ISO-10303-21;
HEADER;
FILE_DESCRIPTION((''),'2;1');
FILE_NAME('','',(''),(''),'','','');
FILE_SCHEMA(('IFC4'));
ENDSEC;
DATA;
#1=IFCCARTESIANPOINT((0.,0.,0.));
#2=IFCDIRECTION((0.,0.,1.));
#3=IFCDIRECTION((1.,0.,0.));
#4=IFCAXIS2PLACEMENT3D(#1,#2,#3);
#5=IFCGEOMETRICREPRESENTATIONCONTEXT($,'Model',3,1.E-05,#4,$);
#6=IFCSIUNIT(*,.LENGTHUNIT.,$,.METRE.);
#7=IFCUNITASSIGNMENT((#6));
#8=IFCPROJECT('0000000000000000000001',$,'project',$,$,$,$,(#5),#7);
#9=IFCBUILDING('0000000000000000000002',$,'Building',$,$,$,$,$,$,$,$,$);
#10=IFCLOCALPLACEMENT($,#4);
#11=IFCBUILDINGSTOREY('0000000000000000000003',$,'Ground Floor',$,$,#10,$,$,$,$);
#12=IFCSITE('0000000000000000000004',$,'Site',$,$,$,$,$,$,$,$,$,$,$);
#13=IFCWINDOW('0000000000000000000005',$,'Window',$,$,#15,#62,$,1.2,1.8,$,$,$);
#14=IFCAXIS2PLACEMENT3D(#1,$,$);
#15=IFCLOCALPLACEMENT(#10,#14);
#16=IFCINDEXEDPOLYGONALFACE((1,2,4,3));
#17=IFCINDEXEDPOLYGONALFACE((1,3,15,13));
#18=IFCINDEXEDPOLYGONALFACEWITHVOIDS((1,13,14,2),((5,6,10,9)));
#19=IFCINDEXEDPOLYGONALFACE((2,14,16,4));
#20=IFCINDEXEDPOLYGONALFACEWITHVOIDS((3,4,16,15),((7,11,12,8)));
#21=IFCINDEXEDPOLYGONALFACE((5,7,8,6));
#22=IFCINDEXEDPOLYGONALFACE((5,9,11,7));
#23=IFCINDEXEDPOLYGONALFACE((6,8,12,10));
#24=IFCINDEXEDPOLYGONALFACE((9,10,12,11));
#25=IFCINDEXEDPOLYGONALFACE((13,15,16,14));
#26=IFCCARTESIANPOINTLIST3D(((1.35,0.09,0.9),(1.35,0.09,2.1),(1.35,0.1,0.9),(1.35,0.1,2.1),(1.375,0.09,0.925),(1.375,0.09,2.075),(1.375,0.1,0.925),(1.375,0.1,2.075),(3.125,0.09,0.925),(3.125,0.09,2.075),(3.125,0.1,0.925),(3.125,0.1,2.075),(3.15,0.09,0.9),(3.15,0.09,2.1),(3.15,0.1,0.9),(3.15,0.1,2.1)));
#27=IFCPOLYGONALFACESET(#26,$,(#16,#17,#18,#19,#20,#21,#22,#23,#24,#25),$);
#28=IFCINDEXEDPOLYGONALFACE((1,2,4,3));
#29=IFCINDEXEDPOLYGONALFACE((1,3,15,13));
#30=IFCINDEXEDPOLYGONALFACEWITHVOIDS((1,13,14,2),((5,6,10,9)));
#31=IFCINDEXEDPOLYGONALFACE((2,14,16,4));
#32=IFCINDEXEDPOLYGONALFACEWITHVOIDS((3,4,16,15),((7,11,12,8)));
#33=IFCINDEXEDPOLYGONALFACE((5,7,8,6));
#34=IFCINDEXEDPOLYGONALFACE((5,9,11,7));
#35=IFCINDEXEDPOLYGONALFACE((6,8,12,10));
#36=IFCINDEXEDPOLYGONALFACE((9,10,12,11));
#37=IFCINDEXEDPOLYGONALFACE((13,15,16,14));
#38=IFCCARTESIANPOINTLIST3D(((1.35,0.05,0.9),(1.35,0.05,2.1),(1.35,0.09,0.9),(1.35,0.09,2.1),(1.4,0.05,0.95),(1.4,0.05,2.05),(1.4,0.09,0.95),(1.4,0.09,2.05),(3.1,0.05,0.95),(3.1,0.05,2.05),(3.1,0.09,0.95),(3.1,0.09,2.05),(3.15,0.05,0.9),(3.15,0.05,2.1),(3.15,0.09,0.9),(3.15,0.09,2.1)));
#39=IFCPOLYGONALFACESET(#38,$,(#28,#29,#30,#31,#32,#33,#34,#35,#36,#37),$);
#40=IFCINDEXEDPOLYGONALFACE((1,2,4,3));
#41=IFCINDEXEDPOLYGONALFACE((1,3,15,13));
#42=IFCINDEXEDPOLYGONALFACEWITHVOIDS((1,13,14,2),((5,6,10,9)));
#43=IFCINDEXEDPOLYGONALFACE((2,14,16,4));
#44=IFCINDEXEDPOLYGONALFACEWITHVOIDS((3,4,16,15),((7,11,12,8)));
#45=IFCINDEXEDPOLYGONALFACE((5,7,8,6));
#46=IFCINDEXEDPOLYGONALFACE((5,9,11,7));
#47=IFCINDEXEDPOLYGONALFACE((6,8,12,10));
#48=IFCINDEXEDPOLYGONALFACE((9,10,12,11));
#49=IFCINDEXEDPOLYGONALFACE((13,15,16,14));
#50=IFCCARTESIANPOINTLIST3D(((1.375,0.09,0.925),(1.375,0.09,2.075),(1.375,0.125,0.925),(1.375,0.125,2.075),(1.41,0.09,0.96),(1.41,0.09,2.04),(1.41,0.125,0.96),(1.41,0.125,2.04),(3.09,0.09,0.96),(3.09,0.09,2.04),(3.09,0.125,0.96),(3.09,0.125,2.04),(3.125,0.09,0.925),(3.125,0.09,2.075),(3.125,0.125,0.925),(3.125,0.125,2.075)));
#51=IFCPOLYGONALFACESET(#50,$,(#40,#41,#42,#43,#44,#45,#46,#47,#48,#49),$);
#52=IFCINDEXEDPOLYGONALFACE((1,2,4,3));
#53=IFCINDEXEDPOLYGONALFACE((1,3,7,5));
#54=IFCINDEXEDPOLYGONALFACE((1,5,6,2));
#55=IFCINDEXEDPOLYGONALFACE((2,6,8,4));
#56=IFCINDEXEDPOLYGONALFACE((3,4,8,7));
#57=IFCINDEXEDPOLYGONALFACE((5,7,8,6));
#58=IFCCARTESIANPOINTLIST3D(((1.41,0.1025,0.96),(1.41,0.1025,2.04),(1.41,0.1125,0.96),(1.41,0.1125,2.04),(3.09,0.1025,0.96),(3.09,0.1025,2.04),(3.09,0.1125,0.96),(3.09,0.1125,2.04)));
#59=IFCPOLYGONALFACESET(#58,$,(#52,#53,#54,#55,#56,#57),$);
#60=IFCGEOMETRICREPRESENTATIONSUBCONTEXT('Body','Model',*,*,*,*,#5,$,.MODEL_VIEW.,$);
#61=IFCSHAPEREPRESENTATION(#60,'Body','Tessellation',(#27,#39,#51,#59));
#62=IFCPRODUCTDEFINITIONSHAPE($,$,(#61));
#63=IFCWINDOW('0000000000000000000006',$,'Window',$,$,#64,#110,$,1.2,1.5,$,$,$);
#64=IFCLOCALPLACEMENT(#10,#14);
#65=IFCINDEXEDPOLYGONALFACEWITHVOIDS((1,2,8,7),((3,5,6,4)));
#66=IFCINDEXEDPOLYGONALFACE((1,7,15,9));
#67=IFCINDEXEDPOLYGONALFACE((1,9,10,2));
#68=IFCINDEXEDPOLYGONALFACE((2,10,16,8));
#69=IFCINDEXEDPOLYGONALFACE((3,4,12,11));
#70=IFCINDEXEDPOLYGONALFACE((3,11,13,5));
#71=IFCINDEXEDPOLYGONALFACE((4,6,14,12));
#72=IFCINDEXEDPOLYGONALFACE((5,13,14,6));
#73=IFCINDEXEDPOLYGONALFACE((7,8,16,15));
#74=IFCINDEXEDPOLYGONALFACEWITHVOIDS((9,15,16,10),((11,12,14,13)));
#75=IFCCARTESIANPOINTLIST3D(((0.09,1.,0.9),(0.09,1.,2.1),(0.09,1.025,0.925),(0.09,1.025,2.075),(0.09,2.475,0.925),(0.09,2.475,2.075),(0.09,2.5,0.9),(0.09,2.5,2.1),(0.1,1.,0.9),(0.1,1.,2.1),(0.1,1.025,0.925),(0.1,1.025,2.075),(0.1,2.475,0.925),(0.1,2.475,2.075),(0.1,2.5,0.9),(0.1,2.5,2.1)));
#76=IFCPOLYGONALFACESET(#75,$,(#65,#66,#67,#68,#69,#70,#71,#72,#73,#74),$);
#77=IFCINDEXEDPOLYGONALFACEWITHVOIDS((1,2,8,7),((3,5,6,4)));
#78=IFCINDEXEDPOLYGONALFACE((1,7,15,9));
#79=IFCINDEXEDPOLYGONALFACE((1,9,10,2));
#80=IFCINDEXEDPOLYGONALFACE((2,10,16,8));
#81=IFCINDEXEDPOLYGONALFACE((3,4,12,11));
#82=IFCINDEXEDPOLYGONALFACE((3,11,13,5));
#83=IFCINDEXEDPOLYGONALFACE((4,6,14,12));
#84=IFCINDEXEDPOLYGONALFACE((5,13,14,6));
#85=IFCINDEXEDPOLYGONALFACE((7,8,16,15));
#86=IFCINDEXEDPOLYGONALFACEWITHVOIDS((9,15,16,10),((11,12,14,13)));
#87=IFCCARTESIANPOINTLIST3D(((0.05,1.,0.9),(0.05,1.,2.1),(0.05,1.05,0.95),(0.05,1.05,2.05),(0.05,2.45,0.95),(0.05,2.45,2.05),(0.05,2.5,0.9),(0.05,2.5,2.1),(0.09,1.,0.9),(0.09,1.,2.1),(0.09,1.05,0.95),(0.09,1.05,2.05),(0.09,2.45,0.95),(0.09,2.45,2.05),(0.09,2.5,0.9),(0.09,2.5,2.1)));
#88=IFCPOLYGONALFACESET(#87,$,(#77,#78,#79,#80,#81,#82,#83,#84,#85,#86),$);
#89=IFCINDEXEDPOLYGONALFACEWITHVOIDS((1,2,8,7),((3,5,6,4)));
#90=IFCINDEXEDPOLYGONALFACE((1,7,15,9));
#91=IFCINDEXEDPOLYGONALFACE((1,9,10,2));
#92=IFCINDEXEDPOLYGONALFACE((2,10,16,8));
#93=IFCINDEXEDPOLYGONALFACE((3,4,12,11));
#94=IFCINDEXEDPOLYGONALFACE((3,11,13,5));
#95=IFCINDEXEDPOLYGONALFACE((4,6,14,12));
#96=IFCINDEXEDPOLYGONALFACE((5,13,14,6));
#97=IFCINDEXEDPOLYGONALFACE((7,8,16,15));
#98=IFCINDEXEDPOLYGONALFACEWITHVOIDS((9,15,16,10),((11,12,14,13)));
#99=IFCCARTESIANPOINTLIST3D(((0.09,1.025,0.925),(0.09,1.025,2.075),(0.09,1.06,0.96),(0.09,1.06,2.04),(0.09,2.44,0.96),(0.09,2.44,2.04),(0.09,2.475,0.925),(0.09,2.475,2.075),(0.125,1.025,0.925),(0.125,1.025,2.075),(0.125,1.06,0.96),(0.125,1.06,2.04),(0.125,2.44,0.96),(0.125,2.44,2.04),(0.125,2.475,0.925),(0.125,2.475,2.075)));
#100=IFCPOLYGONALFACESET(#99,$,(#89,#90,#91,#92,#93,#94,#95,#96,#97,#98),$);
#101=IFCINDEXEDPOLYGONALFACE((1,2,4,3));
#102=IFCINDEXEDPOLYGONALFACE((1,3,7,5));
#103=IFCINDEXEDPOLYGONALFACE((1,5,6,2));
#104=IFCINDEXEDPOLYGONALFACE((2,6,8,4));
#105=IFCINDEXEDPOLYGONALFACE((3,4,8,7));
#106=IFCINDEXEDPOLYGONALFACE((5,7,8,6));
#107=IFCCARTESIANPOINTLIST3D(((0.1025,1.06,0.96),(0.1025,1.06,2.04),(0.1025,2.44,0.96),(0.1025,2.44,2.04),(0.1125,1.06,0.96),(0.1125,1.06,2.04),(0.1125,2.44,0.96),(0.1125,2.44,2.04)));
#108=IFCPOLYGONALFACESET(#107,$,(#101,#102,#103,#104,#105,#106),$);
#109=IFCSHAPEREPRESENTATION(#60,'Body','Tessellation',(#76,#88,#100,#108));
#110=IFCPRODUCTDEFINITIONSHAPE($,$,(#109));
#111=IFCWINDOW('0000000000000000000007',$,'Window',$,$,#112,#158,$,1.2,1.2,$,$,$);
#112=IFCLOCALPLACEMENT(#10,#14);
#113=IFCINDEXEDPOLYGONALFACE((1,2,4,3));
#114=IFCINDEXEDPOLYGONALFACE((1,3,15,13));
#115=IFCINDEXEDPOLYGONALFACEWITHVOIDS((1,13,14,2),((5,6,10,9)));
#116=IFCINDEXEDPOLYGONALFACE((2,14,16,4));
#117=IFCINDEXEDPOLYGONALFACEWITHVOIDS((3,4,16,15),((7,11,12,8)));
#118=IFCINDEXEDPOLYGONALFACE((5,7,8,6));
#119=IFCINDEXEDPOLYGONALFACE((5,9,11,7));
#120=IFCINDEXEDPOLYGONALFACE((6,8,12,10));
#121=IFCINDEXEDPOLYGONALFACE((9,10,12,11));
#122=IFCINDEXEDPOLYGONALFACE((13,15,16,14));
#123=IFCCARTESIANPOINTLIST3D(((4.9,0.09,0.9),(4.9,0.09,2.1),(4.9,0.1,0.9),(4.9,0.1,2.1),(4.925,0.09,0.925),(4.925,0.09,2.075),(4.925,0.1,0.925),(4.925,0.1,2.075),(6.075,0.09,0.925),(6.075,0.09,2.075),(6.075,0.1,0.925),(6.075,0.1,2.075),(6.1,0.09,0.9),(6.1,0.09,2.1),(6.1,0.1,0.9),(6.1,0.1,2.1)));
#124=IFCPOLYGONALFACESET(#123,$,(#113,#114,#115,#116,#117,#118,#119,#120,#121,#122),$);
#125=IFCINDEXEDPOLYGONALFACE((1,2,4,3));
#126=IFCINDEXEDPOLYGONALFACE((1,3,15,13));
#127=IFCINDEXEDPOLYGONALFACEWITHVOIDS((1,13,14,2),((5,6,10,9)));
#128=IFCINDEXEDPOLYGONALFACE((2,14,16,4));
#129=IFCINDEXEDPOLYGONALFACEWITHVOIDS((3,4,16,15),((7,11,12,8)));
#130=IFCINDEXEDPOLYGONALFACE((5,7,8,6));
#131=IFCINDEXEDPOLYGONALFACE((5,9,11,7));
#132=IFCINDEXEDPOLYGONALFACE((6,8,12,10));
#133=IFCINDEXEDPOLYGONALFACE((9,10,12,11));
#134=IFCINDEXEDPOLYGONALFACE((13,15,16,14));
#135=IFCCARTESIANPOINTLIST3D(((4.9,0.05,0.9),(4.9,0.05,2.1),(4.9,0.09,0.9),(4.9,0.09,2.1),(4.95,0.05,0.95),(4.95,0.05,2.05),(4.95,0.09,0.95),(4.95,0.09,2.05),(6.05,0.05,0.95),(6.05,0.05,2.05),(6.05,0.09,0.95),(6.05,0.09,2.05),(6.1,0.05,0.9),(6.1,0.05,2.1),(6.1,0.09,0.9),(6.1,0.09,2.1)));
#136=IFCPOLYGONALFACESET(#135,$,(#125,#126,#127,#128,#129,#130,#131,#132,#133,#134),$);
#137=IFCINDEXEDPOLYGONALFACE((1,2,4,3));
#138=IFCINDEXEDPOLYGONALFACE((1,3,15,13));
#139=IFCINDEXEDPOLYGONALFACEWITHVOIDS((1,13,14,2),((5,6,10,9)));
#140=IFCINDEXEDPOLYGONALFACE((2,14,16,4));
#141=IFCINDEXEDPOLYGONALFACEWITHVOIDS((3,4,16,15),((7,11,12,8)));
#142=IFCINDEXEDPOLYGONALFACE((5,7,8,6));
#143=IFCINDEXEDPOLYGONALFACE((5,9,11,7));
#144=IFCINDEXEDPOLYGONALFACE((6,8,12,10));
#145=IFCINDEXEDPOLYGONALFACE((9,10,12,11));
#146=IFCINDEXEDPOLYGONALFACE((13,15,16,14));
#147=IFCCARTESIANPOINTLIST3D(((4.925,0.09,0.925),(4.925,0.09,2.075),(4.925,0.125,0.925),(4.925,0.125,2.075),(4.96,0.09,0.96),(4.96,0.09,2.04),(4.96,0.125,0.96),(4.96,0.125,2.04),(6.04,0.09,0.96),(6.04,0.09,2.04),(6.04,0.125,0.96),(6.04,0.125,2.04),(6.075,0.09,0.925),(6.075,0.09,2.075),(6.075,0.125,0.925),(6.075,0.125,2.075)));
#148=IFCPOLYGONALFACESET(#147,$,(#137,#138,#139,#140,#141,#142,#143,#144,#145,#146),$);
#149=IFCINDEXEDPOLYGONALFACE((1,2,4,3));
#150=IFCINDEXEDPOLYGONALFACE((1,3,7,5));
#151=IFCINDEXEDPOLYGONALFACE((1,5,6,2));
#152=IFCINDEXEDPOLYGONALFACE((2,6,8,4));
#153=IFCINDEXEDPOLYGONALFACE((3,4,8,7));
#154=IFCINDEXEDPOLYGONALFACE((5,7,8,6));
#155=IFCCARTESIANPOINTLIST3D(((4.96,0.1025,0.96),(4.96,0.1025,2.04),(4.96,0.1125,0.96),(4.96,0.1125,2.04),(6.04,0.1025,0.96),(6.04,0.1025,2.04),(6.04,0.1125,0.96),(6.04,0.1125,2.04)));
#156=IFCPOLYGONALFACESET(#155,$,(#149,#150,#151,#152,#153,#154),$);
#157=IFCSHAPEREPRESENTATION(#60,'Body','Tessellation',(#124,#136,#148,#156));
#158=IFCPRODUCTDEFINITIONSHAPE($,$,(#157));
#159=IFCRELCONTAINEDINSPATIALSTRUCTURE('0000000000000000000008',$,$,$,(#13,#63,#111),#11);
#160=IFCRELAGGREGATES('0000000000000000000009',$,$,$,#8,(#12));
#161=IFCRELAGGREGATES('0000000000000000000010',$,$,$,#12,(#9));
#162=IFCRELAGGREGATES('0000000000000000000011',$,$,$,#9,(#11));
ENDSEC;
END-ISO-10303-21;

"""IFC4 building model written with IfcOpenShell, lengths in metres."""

from ifc_helpers import new_model, si_unit, frame, origin_with_axes, place, context, subcontext, project, spatial, line, indexed_curve, outline, extrude, element, save


model = new_model("IFC4")

# Units and contexts
model_context = context("Model", 3, precision=1e-05, world=origin_with_axes())
body_context = subcontext(model_context, "Body", "Model", "MODEL_VIEW")
ifc_project = project(units=[si_unit("LENGTHUNIT", "METRE")], contexts=[model_context])

# Site, building, storey
site = spatial("IfcSite", under=ifc_project, Name="Site")
building = spatial("IfcBuilding", under=site, Name="Building")
storey_placement = place(None, origin_with_axes())
storey = spatial("IfcBuildingStorey", under=building, at=storey_placement, Name="Ground Floor")

# Windows
window_1_placement = place(storey_placement, frame((1.35, 0.0, 0.9), z_axis=(0.0, 0.0, 1.0), x_axis=(1.0, 0.0, 0.0)))
element("IfcWindow", 1, at=window_1_placement, inside=storey, Name="Window", OverallHeight=1.2, OverallWidth=1.8, context=body_context, shape_type="SweptSolid", body=[
    extrude(outline(indexed_curve([(0.0, 0.0), (1.8, 0.0), (1.8, 1.2), (0.0, 1.2)], segments=[line(1, 2, 3, 4, 1)]), holes=[indexed_curve([(0.025, 0.025), (1.775, 0.025), (1.775, 1.175), (0.025, 1.175)], segments=[line(1, 2, 3, 4, 1)])]), frame((0.0, 0.09, 0.0), z_axis=(0.0, -1.0, 0.0), x_axis=(1.0, 0.0, 0.0)), (0.0, 0.0, -1.0), 0.01),
    extrude(outline(indexed_curve([(0.0, 0.0), (1.8, 0.0), (1.8, 1.2), (0.0, 1.2)], segments=[line(1, 2, 3, 4, 1)]), holes=[indexed_curve([(0.05, 0.05), (1.75, 0.05), (1.75, 1.15), (0.05, 1.15)], segments=[line(1, 2, 3, 4, 1)])]), frame((0.0, 0.05, 0.0), z_axis=(0.0, -1.0, 0.0), x_axis=(1.0, 0.0, 0.0)), (0.0, 0.0, -1.0), 0.04),
    extrude(outline(indexed_curve([(0.0, 0.0), (1.75, 0.0), (1.75, 1.15), (0.0, 1.15)], segments=[line(1, 2, 3, 4, 1)]), holes=[indexed_curve([(0.035, 0.035), (1.715, 0.035), (1.715, 1.115), (0.035, 1.115)], segments=[line(1, 2, 3, 4, 1)])]), frame((0.025, 0.09, 0.025), z_axis=(0.0, -1.0, 0.0), x_axis=(1.0, 0.0, 0.0)), (0.0, 0.0, -1.0), 0.035),
    extrude(outline(indexed_curve([(0.035, 0.035), (1.715, 0.035), (1.715, 1.115), (0.035, 1.115)], segments=[line(1, 2, 3, 4, 1)])), frame((0.025, 0.1025, 0.025), z_axis=(0.0, -1.0, 0.0), x_axis=(1.0, 0.0, 0.0)), (0.0, 0.0, -1.0), 0.01),
])
window_2_placement = place(storey_placement, frame((0.0, 2.5, 0.9), z_axis=(0.0, 0.0, 1.0), x_axis=(0.0, -1.0, 0.0)))
element("IfcWindow", 2, at=window_2_placement, inside=storey, Name="Window", OverallHeight=1.2, OverallWidth=1.5, context=body_context, shape_type="SweptSolid", body=[
    extrude(outline(indexed_curve([(0.0, 0.0), (1.5, 0.0), (1.5, 1.2), (0.0, 1.2)], segments=[line(1, 2, 3, 4, 1)]), holes=[indexed_curve([(0.025, 0.025), (1.475, 0.025), (1.475, 1.175), (0.025, 1.175)], segments=[line(1, 2, 3, 4, 1)])]), frame((0.0, 0.09, 0.0), z_axis=(0.0, -1.0, 0.0), x_axis=(1.0, 0.0, 0.0)), (0.0, 0.0, -1.0), 0.01),
    extrude(outline(indexed_curve([(0.0, 0.0), (1.5, 0.0), (1.5, 1.2), (0.0, 1.2)], segments=[line(1, 2, 3, 4, 1)]), holes=[indexed_curve([(0.05, 0.05), (1.45, 0.05), (1.45, 1.15), (0.05, 1.15)], segments=[line(1, 2, 3, 4, 1)])]), frame((0.0, 0.05, 0.0), z_axis=(0.0, -1.0, 0.0), x_axis=(1.0, 0.0, 0.0)), (0.0, 0.0, -1.0), 0.04),
    extrude(outline(indexed_curve([(0.0, 0.0), (1.45, 0.0), (1.45, 1.15), (0.0, 1.15)], segments=[line(1, 2, 3, 4, 1)]), holes=[indexed_curve([(0.035, 0.035), (1.415, 0.035), (1.415, 1.115), (0.035, 1.115)], segments=[line(1, 2, 3, 4, 1)])]), frame((0.025, 0.09, 0.025), z_axis=(0.0, -1.0, 0.0), x_axis=(1.0, 0.0, 0.0)), (0.0, 0.0, -1.0), 0.035),
    extrude(outline(indexed_curve([(0.035, 0.035), (1.415, 0.035), (1.415, 1.115), (0.035, 1.115)], segments=[line(1, 2, 3, 4, 1)])), frame((0.025, 0.1025, 0.025), z_axis=(0.0, -1.0, 0.0), x_axis=(1.0, 0.0, 0.0)), (0.0, 0.0, -1.0), 0.01),
])
window_3_placement = place(storey_placement, frame((4.9, 0.0, 0.9), z_axis=(0.0, 0.0, 1.0), x_axis=(1.0, 0.0, 0.0)))
element("IfcWindow", 3, at=window_3_placement, inside=storey, Name="Window", OverallHeight=1.2, OverallWidth=1.2, context=body_context, shape_type="SweptSolid", body=[
    extrude(outline(indexed_curve([(0.0, 0.0), (1.2, 0.0), (1.2, 1.2), (0.0, 1.2)], segments=[line(1, 2, 3, 4, 1)]), holes=[indexed_curve([(0.025, 0.025), (1.175, 0.025), (1.175, 1.175), (0.025, 1.175)], segments=[line(1, 2, 3, 4, 1)])]), frame((0.0, 0.09, 0.0), z_axis=(0.0, -1.0, 0.0), x_axis=(1.0, 0.0, 0.0)), (0.0, 0.0, -1.0), 0.01),
    extrude(outline(indexed_curve([(0.0, 0.0), (1.2, 0.0), (1.2, 1.2), (0.0, 1.2)], segments=[line(1, 2, 3, 4, 1)]), holes=[indexed_curve([(0.05, 0.05), (1.15, 0.05), (1.15, 1.15), (0.05, 1.15)], segments=[line(1, 2, 3, 4, 1)])]), frame((0.0, 0.05, 0.0), z_axis=(0.0, -1.0, 0.0), x_axis=(1.0, 0.0, 0.0)), (0.0, 0.0, -1.0), 0.04),
    extrude(outline(indexed_curve([(0.0, 0.0), (1.15, 0.0), (1.15, 1.15), (0.0, 1.15)], segments=[line(1, 2, 3, 4, 1)]), holes=[indexed_curve([(0.035, 0.035), (1.115, 0.035), (1.115, 1.115), (0.035, 1.115)], segments=[line(1, 2, 3, 4, 1)])]), frame((0.025, 0.09, 0.025), z_axis=(0.0, -1.0, 0.0), x_axis=(1.0, 0.0, 0.0)), (0.0, 0.0, -1.0), 0.035),
    extrude(outline(indexed_curve([(0.035, 0.035), (1.115, 0.035), (1.115, 1.115), (0.035, 1.115)], segments=[line(1, 2, 3, 4, 1)])), frame((0.025, 0.1025, 0.025), z_axis=(0.0, -1.0, 0.0), x_axis=(1.0, 0.0, 0.0)), (0.0, 0.0, -1.0), 0.01),
])

save(model, "model.ifc")
